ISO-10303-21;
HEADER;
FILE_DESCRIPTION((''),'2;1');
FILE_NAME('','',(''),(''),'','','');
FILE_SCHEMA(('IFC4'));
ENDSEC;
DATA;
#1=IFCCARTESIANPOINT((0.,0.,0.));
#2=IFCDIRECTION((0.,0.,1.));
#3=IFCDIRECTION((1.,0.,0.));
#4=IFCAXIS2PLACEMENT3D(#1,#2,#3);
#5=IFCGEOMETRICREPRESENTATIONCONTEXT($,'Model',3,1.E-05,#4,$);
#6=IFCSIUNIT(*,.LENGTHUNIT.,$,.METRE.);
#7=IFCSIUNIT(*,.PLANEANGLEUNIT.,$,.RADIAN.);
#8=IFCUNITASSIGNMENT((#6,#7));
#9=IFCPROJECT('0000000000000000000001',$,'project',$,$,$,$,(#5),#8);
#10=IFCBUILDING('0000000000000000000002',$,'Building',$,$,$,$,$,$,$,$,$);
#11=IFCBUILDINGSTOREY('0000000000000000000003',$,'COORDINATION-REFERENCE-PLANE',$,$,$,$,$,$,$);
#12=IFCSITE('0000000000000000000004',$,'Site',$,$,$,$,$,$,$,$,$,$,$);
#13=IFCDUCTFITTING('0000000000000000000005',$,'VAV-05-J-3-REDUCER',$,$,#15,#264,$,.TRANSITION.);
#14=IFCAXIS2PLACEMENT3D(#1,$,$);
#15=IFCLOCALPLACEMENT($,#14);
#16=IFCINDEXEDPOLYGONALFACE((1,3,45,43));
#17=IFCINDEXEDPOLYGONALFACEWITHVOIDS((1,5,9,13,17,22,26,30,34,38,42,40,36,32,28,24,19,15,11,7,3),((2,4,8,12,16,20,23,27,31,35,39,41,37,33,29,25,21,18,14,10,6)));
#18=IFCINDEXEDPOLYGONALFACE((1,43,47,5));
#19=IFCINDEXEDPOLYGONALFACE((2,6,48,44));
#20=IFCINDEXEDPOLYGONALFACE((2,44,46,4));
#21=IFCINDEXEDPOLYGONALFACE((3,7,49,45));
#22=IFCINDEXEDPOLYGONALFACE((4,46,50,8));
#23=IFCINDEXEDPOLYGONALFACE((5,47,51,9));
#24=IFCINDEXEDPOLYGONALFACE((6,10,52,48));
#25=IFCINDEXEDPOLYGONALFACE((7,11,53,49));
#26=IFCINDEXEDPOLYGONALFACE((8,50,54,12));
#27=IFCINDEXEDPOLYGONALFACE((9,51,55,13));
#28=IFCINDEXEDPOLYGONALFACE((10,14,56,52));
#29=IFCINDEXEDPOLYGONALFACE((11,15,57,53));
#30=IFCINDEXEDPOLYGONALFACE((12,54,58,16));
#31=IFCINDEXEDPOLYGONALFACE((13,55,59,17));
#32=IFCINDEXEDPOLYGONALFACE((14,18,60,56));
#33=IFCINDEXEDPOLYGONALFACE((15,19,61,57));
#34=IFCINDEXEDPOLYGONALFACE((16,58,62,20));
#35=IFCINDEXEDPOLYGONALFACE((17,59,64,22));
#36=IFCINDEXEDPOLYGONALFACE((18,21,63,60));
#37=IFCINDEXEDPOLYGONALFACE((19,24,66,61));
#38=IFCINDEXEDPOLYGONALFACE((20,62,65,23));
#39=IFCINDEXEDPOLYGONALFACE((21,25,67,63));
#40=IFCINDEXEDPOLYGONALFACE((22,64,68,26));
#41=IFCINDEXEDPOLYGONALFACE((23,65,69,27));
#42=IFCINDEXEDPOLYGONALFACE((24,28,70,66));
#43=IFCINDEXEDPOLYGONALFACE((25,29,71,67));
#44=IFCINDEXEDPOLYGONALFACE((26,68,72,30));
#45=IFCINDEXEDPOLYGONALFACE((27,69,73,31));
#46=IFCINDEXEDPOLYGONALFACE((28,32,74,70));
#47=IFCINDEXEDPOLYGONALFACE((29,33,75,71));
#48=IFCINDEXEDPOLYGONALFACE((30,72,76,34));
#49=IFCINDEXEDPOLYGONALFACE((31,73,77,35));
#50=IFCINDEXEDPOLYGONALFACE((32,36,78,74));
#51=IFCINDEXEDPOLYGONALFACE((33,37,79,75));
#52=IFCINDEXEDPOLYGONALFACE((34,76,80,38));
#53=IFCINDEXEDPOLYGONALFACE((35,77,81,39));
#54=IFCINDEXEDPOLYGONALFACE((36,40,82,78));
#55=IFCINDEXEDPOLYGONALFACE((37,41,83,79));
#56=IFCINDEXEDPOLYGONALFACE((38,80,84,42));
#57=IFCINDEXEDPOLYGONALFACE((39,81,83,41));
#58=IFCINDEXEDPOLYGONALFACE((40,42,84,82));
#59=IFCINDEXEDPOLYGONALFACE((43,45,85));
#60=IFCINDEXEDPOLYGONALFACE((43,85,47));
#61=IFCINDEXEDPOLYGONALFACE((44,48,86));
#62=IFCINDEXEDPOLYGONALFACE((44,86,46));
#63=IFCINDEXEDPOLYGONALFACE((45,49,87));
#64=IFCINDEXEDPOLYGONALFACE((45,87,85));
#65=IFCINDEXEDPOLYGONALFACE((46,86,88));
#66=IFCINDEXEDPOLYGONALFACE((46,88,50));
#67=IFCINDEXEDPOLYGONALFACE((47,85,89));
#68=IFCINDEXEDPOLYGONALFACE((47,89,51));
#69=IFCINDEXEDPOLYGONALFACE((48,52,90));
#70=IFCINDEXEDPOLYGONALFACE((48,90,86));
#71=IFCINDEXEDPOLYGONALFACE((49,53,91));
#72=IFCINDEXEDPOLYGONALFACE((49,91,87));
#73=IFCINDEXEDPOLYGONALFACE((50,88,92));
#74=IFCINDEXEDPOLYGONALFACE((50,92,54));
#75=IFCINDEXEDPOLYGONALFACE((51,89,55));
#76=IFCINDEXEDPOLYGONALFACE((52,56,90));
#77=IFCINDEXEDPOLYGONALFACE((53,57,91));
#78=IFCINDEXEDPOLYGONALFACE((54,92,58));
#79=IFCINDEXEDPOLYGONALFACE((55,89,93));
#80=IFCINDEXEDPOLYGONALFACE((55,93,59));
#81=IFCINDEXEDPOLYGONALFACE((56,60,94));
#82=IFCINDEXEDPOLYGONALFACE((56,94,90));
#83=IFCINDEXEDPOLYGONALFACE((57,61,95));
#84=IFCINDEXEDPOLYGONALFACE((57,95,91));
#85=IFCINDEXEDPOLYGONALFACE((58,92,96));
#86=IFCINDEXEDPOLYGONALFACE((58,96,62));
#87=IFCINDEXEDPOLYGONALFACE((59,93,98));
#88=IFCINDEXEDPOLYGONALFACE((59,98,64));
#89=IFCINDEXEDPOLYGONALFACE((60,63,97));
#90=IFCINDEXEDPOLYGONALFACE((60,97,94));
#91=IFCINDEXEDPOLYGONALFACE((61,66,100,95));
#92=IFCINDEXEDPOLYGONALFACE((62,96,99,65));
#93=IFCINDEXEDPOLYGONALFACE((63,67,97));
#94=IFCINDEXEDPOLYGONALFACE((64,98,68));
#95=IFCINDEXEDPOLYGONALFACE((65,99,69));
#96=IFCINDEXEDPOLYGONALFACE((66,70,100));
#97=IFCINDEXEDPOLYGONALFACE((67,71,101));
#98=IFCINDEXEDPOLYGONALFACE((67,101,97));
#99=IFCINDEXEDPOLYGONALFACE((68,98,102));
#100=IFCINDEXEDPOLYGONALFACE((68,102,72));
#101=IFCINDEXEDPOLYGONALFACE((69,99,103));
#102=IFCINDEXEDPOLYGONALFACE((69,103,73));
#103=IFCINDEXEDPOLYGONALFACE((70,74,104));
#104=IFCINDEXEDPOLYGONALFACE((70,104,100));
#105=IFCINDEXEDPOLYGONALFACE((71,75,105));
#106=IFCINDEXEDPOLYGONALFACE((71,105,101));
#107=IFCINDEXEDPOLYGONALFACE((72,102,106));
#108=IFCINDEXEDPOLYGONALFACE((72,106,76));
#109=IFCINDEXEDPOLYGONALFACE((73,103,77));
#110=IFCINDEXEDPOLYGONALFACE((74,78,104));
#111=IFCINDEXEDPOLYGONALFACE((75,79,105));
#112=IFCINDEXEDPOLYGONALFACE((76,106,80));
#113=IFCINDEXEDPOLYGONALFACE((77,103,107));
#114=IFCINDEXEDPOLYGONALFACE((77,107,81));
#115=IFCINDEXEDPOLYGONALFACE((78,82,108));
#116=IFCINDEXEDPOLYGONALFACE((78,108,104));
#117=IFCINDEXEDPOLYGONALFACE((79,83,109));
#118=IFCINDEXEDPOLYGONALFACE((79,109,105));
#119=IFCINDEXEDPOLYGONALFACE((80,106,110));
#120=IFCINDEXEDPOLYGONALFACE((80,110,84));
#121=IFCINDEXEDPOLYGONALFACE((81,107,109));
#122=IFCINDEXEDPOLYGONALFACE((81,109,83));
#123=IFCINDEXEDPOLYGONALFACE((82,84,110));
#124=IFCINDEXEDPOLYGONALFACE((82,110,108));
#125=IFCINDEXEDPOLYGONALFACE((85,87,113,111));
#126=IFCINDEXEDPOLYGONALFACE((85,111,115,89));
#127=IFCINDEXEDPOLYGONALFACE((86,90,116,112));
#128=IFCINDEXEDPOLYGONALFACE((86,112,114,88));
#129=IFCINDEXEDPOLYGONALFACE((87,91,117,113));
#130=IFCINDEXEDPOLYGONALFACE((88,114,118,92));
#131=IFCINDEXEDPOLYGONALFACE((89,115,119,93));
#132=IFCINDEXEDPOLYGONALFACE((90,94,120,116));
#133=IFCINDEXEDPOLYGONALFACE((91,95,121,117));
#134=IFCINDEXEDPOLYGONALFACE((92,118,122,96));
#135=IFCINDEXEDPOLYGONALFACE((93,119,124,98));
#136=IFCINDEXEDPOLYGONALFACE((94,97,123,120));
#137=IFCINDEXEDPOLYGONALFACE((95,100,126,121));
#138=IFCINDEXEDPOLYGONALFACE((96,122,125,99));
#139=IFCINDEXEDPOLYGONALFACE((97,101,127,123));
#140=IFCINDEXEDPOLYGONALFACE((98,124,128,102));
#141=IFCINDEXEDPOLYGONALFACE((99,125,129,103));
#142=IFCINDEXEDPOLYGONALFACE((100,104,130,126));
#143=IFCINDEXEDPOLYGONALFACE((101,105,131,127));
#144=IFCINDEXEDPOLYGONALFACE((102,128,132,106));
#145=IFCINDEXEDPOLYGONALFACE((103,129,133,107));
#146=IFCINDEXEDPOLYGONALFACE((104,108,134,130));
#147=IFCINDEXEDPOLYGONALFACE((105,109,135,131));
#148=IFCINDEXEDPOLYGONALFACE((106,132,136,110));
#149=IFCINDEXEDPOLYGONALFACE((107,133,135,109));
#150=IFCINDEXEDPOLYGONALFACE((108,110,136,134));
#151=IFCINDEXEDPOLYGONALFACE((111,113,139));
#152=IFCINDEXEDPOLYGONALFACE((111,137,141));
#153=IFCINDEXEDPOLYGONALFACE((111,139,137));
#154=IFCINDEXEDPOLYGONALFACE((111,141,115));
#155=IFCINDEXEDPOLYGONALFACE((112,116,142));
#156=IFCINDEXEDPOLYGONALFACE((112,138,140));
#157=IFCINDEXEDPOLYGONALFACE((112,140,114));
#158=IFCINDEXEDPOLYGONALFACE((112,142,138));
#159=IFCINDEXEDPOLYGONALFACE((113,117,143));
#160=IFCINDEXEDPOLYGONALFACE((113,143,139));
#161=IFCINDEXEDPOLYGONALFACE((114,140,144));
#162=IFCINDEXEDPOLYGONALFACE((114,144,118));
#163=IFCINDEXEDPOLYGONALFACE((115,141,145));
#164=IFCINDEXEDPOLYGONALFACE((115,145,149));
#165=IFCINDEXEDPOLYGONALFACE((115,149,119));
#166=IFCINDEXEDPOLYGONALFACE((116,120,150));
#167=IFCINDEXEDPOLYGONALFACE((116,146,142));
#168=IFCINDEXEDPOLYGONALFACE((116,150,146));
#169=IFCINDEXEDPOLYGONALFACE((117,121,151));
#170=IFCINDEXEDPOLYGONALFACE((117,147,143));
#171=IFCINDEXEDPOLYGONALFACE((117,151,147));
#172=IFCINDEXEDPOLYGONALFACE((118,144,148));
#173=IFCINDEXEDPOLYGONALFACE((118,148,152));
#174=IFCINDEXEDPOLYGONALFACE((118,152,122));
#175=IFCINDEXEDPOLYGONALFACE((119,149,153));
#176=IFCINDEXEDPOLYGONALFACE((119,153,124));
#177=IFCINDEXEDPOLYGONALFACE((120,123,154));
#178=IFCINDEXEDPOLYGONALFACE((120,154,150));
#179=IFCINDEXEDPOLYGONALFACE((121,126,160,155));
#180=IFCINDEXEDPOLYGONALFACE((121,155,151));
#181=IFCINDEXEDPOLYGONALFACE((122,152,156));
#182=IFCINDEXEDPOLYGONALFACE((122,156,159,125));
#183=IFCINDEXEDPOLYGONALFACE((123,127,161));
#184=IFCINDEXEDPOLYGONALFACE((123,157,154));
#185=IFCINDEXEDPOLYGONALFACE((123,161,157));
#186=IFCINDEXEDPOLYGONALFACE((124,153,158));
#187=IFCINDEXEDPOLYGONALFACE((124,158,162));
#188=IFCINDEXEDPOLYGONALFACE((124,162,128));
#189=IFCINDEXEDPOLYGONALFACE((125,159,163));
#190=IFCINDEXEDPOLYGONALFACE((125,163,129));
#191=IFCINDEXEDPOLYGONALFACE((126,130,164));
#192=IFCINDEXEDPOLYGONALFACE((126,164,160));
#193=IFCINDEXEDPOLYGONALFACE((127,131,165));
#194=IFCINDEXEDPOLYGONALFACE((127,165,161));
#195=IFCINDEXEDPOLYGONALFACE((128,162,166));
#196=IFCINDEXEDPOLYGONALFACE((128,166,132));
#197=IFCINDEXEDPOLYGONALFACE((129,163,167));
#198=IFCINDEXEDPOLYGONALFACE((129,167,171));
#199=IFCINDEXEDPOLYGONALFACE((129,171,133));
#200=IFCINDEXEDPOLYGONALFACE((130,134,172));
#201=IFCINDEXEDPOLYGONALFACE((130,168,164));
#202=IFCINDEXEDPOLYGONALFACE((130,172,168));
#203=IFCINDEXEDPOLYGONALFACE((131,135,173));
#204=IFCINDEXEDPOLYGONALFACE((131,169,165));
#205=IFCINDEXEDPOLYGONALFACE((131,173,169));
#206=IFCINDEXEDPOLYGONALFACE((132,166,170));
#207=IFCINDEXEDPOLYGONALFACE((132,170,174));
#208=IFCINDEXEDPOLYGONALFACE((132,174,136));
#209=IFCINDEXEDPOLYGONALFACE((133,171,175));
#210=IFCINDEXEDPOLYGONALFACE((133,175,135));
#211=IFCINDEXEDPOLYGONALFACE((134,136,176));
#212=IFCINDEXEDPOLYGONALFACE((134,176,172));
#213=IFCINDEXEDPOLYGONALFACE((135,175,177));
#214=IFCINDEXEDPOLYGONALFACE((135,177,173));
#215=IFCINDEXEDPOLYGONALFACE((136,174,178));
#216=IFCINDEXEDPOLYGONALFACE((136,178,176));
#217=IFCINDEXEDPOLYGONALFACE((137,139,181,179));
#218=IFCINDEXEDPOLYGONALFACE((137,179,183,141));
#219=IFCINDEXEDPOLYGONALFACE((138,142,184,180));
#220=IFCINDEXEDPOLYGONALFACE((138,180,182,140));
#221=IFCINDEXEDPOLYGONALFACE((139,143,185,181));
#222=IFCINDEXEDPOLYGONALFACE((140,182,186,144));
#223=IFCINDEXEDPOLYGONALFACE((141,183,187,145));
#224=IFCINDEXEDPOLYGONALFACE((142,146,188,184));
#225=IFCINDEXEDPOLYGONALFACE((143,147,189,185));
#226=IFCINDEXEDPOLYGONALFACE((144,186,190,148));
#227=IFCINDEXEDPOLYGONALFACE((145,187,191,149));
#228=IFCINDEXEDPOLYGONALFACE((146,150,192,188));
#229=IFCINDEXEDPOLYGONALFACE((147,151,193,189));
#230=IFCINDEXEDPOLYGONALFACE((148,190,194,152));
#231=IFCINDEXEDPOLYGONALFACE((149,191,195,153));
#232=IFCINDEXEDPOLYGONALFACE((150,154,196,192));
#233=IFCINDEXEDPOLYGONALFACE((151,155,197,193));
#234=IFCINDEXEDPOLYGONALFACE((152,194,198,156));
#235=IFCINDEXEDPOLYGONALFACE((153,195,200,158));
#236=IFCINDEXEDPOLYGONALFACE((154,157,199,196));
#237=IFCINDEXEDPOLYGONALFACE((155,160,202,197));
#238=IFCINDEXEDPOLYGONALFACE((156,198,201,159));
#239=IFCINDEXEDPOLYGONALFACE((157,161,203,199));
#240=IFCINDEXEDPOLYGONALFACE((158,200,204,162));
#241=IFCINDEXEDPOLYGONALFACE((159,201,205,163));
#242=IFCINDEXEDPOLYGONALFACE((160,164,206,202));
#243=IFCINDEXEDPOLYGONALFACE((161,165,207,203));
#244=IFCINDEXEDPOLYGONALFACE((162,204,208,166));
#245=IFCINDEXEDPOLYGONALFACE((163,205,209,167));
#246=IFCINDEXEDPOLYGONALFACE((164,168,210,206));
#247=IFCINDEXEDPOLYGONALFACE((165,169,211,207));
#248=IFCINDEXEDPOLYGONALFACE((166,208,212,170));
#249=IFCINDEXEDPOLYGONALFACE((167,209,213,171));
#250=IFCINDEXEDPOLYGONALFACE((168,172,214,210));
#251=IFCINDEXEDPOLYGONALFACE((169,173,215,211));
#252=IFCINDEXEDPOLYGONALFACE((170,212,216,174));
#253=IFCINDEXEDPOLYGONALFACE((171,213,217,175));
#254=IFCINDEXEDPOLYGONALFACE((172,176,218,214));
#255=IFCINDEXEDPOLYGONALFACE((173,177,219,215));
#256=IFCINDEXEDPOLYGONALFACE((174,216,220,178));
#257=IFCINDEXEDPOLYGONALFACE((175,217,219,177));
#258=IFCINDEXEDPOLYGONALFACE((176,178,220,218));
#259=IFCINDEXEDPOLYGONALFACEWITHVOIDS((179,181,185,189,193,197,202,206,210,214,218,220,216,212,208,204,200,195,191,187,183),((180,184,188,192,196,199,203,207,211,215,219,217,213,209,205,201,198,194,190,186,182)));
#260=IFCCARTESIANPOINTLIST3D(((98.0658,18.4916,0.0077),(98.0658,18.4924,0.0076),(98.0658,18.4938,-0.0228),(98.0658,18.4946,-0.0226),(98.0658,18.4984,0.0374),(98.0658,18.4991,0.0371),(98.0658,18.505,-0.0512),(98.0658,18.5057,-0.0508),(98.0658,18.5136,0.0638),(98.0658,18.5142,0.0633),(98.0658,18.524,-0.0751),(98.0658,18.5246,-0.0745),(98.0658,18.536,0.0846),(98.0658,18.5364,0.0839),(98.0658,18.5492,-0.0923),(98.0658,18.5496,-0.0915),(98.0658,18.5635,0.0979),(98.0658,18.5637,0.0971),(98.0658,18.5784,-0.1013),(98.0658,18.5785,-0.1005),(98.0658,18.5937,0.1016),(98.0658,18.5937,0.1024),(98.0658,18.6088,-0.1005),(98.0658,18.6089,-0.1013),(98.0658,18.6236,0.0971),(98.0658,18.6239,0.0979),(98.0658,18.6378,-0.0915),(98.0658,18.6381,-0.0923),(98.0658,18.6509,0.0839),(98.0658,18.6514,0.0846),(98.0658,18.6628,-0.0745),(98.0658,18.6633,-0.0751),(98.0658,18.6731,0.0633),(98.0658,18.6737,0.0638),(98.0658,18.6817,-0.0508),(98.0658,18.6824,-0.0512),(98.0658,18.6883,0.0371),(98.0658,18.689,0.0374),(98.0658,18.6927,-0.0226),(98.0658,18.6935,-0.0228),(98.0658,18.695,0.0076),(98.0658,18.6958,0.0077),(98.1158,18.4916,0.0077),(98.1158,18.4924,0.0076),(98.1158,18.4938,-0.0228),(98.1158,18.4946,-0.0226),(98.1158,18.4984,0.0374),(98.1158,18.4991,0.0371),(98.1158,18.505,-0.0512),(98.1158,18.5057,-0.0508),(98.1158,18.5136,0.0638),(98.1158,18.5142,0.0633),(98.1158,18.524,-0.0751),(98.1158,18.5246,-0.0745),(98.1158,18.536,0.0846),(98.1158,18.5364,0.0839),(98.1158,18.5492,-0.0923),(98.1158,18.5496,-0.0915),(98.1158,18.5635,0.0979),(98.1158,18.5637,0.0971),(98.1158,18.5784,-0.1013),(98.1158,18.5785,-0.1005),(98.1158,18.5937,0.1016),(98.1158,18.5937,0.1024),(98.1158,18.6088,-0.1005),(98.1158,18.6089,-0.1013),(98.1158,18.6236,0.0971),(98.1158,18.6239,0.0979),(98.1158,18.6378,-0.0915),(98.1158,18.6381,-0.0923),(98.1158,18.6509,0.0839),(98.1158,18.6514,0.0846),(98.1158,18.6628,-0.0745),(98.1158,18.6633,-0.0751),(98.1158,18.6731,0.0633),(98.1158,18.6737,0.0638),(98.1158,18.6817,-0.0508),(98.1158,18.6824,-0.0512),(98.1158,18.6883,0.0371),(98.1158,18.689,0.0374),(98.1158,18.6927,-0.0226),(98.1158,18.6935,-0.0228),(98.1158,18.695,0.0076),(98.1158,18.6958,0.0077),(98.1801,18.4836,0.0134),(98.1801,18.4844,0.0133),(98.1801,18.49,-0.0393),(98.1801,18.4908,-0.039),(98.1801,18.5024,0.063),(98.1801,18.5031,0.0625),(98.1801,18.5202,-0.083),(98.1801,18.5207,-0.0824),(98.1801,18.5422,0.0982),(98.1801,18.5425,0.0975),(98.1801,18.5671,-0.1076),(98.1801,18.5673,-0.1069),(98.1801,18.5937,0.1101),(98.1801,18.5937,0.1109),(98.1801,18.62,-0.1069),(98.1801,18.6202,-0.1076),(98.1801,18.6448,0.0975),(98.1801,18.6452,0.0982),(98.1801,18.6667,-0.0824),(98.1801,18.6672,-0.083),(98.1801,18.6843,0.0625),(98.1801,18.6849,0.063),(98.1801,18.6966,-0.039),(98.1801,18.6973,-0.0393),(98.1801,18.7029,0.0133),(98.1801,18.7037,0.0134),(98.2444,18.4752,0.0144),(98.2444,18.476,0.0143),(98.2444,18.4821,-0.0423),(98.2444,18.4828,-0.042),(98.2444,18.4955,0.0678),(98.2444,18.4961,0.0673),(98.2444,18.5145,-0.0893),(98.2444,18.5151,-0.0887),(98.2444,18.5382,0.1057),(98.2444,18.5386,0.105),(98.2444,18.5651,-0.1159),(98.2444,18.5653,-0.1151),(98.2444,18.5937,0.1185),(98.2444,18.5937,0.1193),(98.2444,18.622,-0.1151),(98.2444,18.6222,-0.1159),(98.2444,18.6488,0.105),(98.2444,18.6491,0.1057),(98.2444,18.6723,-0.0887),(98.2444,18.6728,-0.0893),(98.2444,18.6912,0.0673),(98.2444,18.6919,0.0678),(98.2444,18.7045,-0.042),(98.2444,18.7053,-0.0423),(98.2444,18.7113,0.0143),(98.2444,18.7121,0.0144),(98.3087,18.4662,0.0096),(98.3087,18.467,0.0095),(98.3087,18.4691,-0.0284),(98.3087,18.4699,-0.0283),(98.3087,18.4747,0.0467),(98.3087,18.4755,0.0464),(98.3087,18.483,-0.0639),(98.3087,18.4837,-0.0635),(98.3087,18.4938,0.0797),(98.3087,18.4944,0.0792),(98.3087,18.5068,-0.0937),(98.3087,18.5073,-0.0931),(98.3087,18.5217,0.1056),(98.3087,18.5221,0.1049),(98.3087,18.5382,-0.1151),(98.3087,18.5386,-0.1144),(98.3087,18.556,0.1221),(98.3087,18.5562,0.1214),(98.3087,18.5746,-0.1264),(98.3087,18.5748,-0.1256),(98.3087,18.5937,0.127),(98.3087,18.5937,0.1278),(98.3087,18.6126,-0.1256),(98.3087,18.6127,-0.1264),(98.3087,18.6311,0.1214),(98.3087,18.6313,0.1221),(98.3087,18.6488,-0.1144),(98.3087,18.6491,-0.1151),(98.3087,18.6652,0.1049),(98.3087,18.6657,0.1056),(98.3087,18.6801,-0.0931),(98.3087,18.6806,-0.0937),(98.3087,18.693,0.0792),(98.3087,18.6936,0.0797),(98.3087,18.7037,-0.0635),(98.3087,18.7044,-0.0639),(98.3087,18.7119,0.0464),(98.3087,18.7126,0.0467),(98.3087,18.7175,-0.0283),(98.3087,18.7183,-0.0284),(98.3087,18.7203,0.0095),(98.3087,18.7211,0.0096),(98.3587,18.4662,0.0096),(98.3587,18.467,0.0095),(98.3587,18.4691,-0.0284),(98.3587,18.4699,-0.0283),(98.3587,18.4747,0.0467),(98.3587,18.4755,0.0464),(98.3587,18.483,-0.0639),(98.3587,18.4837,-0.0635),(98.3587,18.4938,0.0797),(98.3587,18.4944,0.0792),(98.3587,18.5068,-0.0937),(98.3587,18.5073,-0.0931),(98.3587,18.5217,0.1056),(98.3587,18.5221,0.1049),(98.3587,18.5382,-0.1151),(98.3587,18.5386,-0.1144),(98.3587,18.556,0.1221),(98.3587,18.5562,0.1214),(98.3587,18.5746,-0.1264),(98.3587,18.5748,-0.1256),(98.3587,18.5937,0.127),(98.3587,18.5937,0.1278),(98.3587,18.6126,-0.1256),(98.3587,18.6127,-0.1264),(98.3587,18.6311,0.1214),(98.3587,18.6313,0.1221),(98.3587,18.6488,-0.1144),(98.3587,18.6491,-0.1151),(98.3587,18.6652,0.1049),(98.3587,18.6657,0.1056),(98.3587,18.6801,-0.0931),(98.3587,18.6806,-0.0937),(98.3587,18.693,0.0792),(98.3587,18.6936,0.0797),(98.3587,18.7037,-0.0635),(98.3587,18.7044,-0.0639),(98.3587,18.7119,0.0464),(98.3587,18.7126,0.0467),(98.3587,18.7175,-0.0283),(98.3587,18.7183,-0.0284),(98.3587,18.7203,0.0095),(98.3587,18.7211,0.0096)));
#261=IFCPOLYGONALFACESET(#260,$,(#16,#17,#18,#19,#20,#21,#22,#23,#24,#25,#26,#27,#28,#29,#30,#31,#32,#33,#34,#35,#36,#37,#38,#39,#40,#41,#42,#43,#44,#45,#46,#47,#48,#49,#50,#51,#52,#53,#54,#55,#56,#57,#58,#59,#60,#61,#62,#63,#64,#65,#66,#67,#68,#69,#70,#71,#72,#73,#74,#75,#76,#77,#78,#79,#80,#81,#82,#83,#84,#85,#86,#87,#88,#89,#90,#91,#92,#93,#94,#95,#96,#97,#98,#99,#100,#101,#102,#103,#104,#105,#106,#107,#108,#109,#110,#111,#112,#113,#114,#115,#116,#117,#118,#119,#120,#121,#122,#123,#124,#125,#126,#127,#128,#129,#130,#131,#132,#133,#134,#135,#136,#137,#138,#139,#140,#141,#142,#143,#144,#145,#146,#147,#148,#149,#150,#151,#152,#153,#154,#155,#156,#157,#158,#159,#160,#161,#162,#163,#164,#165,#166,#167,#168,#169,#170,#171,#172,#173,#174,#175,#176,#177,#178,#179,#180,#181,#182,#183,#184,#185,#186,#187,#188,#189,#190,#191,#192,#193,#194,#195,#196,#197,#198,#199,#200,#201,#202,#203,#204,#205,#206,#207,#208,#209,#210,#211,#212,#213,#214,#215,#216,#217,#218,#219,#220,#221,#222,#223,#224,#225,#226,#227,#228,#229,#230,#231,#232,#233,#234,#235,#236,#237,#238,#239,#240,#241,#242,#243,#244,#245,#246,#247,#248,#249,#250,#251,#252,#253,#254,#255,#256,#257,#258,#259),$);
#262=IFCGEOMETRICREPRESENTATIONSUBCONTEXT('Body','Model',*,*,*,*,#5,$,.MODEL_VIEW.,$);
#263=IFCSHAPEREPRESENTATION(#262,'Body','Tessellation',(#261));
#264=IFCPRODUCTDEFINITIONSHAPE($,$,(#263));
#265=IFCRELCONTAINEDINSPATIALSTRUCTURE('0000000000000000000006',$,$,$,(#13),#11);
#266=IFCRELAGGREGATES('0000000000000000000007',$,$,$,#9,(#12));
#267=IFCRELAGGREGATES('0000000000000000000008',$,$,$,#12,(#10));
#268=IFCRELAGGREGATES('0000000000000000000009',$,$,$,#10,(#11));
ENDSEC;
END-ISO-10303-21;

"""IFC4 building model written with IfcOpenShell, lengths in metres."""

from ifc_helpers import new_model, entity, si_unit, frame, origin_with_axes, place, context, subcontext, project, spatial, element, save


model = new_model("IFC4")

# Units and contexts
model_context = context("Model", 3, precision=1e-05, world=origin_with_axes())
body_context_1 = subcontext(model_context, "Body", "Model", "MODEL_VIEW")
ifc_project = project(units=[si_unit("LENGTHUNIT", "METRE"), si_unit("PLANEANGLEUNIT", "RADIAN")], contexts=[model_context])

# Site, building, storey
site = spatial("IfcSite", under=ifc_project, Name="Site")
building = spatial("IfcBuilding", under=site, Name="Building")
storey = spatial("IfcBuildingStorey", under=building, Name="COORDINATION-REFERENCE-PLANE")

# Duct fitting
for number, where, z_axis, x_axis, name in (
    (1, (98.3587, 18.5937, 0.0), (0.0, -1.0, 0.0), (0.0, 0.0, 1.0), "VAV-05-J-3-REDUCER"),
):
    element("IfcDuctFitting", number, at=place(None, frame(where, z_axis=z_axis, x_axis=x_axis)), inside=storey, Name=name, PredefinedType="TRANSITION", context=body_context_1, shape_type="SweptSolid", body=[
        entity("IfcRevolvedAreaSolid", entity("IfcArbitraryClosedProfileDef", "AREA", None, entity("IfcPolyline", [entity("IfcCartesianPoint", [0.1278, 0.0]), entity("IfcCartesianPoint", [0.1278, 0.05]), entity("IfcCartesianPoint", [0.1024, 0.2429]), entity("IfcCartesianPoint", [0.1024, 0.2929]), entity("IfcCartesianPoint", [0.1016, 0.2929]), entity("IfcCartesianPoint", [0.1016, 0.2429]), entity("IfcCartesianPoint", [0.127, 0.05]), entity("IfcCartesianPoint", [0.127, 0.0]), entity("IfcCartesianPoint", [0.1278, 0.0])])), entity("IfcAxis2Placement3D", entity("IfcCartesianPoint", [0.0, 0.0, 0.0])), entity("IfcAxis1Placement", entity("IfcCartesianPoint", [0.0, 0.0, 0.0]), entity("IfcDirection", [0.0, 1.0, 0.0])), 6.283185),
    ])

save(model, "model.ifc")
